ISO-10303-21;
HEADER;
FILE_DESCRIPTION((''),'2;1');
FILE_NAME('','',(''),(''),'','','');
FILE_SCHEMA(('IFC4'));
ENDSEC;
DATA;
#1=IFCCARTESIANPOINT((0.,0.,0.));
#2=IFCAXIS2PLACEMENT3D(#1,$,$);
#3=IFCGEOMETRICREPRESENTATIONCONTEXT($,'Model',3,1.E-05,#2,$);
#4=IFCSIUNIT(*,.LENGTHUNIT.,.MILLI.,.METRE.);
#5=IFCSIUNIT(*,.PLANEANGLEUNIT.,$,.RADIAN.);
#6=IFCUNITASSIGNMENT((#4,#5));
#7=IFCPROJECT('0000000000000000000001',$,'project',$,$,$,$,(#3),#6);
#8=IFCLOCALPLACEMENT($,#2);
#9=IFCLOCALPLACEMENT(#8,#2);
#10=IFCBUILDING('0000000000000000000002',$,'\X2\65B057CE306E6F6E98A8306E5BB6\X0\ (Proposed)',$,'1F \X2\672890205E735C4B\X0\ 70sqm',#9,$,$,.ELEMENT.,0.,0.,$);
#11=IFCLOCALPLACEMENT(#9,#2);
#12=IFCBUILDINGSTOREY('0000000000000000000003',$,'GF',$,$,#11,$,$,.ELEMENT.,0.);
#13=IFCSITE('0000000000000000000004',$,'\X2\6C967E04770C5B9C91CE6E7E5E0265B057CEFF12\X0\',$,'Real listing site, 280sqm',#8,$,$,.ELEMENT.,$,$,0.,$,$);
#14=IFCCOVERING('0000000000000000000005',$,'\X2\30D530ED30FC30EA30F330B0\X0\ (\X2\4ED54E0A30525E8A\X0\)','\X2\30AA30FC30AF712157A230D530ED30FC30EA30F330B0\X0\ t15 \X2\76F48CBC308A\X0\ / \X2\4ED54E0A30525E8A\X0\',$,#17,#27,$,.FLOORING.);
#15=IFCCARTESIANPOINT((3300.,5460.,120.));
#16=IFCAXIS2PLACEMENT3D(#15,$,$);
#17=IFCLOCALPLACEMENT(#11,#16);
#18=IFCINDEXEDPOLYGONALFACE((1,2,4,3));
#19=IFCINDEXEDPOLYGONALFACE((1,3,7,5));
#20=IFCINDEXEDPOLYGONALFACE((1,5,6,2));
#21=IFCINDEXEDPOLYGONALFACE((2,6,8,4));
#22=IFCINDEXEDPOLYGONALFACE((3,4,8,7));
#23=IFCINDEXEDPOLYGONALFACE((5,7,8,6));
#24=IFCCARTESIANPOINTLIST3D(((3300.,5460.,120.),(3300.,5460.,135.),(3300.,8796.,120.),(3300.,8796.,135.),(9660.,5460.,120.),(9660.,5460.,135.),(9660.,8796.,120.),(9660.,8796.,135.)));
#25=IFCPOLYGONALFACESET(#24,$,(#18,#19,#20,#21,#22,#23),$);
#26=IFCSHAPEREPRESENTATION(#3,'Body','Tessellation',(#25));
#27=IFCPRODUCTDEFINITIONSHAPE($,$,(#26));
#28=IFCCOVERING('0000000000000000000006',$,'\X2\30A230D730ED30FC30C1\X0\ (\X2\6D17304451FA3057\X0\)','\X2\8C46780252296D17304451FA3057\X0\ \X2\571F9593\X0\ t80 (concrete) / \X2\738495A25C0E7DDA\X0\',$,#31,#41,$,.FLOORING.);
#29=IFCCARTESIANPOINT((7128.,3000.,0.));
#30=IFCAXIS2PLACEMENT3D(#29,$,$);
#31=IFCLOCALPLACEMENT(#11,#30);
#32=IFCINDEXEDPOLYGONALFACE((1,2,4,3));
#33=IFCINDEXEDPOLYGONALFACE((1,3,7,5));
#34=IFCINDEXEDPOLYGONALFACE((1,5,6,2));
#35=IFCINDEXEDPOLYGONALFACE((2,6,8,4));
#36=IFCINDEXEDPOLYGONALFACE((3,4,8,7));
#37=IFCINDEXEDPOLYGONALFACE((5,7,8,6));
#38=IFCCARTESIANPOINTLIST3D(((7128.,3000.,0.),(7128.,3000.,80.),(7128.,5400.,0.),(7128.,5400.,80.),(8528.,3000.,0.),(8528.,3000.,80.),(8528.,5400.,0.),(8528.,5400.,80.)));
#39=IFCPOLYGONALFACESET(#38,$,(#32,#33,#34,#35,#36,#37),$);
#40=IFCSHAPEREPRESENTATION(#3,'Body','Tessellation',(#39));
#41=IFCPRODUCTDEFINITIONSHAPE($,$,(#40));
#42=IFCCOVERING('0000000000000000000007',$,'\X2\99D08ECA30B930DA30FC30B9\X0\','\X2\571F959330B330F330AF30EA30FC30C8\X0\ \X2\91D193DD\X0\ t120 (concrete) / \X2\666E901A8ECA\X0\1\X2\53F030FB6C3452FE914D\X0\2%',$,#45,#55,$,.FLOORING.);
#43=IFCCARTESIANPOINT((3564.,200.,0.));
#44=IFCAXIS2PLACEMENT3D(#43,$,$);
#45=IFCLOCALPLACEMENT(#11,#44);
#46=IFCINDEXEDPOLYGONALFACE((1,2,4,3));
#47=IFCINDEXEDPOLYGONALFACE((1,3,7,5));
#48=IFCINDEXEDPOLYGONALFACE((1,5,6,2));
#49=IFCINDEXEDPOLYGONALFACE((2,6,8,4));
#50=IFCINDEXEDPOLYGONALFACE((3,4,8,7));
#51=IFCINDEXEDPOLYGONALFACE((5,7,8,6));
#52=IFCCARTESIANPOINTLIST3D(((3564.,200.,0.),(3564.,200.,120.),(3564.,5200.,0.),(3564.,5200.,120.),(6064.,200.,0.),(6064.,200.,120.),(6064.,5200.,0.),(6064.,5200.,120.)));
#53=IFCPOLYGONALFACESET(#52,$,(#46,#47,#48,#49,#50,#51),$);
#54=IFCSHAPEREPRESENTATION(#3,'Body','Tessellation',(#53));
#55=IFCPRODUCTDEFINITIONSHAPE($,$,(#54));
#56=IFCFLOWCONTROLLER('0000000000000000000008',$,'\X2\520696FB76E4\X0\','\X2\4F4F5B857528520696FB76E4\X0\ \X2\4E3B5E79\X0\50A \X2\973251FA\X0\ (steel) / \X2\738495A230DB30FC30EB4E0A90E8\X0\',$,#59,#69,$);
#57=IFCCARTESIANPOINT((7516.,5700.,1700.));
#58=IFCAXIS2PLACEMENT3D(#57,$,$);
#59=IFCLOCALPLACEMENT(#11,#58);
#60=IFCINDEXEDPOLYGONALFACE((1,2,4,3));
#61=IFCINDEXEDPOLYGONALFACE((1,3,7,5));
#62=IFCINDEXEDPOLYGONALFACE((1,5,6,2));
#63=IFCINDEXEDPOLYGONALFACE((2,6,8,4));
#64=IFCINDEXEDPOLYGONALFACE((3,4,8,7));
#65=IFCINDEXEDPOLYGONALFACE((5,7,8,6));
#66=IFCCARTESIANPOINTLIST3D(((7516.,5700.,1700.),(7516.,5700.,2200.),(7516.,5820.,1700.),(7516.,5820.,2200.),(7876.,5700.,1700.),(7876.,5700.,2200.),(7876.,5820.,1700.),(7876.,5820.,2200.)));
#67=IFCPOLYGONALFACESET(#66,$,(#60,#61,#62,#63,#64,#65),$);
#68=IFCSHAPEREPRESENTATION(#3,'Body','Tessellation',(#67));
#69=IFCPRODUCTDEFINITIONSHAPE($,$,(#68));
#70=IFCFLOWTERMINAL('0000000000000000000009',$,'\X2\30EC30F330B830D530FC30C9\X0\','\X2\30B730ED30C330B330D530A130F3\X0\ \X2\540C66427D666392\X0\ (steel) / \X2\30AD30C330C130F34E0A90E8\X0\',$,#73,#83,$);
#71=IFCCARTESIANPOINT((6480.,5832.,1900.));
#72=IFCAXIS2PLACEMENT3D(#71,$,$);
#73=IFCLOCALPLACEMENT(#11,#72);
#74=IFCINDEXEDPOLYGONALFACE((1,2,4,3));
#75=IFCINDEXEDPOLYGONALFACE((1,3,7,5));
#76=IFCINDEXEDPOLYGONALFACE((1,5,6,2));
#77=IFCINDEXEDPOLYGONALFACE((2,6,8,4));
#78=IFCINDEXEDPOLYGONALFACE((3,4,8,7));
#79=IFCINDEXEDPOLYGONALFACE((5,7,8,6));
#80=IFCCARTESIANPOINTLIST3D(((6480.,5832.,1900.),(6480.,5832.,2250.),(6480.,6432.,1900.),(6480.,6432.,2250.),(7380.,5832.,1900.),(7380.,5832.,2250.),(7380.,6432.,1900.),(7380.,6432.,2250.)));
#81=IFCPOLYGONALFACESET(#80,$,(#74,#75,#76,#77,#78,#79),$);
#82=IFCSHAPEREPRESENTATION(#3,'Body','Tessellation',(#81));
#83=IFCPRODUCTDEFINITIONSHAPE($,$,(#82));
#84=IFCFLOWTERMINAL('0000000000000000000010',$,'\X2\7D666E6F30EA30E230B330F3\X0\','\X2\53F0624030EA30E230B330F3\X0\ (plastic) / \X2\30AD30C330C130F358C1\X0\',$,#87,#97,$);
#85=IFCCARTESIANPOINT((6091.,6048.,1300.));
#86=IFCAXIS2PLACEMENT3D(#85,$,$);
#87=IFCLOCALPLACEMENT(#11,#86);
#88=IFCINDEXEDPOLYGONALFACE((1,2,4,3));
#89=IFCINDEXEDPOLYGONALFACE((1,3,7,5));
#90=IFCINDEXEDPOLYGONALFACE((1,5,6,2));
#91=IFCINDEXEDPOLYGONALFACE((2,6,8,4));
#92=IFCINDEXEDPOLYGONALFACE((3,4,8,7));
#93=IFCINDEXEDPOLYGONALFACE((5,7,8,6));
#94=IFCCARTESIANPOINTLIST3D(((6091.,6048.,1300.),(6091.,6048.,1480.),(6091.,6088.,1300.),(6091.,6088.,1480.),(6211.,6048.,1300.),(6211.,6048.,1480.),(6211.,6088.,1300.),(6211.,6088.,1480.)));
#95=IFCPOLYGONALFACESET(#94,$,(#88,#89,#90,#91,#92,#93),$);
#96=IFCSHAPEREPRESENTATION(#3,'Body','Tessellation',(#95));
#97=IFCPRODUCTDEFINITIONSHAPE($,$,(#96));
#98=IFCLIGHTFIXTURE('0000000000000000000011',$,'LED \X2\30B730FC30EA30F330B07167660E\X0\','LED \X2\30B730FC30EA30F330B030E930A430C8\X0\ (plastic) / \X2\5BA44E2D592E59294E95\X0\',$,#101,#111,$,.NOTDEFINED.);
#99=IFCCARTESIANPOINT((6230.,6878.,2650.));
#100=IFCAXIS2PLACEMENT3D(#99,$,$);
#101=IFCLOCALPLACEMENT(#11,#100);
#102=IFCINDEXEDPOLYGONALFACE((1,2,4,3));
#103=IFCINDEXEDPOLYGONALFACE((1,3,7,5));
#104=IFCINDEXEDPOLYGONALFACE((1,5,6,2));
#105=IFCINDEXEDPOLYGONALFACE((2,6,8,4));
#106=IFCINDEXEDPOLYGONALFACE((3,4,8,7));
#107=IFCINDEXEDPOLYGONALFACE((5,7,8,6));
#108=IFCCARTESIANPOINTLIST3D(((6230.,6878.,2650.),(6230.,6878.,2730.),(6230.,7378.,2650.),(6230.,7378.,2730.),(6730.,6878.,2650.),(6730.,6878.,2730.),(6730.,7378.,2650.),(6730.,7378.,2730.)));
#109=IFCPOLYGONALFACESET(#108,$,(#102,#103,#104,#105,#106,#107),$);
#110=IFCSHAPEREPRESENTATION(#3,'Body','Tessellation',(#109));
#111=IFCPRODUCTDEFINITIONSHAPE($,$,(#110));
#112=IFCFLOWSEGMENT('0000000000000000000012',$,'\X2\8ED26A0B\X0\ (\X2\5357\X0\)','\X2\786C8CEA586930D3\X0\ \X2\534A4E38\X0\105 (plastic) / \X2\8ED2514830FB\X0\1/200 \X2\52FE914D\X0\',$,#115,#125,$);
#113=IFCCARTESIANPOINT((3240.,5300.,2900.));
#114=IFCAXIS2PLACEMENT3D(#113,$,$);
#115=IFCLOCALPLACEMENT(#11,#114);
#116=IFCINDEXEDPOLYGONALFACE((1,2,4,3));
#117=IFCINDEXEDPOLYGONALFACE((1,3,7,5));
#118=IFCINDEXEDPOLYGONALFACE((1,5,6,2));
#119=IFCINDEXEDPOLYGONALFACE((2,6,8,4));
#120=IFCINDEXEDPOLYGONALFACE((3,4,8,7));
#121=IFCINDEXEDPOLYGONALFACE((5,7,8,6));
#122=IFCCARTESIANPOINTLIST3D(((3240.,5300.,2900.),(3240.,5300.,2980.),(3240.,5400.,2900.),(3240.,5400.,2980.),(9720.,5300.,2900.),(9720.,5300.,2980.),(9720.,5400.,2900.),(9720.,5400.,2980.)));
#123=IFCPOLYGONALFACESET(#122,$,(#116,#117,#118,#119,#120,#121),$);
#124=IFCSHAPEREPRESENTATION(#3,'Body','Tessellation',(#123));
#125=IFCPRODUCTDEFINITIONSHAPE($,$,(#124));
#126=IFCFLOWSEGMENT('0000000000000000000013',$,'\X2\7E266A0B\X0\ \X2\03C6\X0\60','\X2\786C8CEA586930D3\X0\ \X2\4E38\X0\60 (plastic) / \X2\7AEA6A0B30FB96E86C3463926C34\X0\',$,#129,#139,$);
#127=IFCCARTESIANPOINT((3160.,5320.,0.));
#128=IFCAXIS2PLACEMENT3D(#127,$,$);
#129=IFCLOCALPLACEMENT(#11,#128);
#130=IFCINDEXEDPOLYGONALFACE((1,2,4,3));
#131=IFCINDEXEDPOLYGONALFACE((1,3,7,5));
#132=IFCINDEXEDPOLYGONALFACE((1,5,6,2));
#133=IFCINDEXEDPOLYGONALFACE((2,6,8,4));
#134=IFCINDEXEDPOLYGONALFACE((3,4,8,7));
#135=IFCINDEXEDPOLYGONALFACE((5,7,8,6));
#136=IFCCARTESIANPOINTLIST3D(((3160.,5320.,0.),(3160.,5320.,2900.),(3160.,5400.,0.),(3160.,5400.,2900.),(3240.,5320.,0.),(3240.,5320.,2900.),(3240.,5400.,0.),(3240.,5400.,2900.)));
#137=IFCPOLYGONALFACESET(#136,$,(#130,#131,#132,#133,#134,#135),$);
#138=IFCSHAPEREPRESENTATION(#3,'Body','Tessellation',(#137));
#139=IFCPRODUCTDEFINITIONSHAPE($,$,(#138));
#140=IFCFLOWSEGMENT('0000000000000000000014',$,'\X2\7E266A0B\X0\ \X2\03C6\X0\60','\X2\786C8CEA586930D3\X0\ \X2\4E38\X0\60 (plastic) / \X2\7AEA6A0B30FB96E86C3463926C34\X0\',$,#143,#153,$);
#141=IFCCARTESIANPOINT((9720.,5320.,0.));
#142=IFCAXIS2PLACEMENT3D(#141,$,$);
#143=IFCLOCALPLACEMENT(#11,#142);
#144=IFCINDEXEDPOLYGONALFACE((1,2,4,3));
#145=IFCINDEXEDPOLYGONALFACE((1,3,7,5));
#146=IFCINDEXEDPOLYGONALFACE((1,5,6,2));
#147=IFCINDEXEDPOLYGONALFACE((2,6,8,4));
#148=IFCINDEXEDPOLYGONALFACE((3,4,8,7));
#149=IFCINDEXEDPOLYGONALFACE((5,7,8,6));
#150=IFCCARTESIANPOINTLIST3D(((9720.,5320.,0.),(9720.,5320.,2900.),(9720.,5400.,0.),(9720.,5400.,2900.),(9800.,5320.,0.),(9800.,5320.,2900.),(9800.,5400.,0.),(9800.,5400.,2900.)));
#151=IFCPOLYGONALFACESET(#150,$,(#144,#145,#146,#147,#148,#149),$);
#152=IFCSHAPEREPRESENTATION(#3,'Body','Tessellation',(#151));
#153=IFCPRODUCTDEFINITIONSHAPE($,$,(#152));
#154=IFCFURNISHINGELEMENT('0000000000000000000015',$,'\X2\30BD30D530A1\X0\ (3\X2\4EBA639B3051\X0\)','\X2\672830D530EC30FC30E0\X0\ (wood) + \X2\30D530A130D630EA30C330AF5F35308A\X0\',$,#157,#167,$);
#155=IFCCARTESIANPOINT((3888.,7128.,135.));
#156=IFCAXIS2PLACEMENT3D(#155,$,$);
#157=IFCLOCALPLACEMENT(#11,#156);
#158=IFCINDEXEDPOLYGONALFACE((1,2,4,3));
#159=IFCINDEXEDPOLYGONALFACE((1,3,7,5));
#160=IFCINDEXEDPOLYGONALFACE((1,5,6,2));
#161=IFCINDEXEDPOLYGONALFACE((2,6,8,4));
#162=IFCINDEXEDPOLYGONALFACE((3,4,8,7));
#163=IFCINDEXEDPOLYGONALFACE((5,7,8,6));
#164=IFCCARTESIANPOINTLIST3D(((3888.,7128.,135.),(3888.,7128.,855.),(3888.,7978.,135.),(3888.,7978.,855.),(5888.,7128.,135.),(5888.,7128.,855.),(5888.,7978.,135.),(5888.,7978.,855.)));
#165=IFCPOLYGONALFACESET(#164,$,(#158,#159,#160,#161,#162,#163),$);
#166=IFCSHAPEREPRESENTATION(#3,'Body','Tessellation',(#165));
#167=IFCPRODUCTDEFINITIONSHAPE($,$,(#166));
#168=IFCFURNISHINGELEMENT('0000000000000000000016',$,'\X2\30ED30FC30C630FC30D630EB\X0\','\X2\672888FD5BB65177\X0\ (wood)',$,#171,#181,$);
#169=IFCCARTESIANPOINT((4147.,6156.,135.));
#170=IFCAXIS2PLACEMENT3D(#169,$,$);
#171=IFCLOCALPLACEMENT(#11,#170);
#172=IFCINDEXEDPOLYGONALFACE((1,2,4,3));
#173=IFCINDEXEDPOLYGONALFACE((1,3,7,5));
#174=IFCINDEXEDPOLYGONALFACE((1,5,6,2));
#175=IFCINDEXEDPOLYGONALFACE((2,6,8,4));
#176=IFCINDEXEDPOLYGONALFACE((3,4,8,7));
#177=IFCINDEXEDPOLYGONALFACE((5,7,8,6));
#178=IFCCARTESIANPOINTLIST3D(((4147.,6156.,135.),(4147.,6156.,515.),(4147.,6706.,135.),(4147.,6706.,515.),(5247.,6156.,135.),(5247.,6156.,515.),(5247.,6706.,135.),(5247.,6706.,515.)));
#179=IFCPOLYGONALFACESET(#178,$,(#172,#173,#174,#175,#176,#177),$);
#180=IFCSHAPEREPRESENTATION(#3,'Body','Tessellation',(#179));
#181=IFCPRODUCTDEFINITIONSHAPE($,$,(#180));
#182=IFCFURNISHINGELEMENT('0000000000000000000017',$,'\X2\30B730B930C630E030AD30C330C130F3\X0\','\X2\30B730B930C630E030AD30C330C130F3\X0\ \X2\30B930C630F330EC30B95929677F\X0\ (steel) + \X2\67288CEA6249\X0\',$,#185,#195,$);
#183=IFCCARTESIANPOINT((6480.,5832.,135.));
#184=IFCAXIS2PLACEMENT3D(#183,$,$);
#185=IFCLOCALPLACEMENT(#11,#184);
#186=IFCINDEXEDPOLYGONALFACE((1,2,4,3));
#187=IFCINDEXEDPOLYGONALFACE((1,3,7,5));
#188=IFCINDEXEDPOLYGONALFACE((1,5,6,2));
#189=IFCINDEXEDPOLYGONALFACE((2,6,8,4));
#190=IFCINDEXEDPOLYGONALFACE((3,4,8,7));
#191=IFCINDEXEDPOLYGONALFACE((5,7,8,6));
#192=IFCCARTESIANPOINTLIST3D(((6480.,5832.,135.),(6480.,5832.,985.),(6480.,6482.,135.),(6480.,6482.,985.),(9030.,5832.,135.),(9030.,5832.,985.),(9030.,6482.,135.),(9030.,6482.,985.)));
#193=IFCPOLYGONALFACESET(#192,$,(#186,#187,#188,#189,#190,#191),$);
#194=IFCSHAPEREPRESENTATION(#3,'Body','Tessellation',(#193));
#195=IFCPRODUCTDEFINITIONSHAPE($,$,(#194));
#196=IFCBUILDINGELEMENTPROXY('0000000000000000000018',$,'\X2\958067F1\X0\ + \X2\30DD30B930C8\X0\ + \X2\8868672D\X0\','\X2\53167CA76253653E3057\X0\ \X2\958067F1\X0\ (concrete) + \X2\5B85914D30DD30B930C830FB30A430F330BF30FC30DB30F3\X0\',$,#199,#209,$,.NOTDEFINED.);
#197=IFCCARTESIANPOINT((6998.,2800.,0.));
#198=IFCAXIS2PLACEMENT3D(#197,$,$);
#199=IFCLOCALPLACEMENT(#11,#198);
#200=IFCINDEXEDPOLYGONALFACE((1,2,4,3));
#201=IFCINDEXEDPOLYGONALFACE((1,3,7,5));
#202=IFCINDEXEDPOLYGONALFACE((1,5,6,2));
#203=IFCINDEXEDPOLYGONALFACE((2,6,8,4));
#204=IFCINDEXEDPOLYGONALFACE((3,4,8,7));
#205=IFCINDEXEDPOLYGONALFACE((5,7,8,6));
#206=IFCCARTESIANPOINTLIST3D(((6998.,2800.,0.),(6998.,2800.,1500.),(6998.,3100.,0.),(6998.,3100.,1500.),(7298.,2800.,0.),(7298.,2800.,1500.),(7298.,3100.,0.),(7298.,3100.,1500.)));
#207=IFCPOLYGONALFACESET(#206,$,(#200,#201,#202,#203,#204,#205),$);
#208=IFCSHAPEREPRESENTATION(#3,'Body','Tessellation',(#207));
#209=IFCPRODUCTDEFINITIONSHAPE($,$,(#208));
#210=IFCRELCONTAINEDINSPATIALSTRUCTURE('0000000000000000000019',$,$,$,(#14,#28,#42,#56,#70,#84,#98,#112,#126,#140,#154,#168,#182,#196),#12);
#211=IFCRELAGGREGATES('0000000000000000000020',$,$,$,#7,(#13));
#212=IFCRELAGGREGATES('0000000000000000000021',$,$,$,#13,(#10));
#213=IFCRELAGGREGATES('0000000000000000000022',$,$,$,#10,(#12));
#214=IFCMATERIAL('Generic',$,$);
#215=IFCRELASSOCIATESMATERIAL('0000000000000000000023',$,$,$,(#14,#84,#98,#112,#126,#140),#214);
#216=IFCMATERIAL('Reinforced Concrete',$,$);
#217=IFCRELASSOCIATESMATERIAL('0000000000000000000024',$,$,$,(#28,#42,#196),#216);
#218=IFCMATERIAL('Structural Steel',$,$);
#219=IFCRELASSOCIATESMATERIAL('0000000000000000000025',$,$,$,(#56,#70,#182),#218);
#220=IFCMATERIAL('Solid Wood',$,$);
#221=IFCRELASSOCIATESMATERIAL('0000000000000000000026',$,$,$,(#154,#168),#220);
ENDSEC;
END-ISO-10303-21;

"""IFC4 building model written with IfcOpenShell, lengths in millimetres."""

from ifc_helpers import new_model, si_unit, frame, frame_2d, origin, place, context, project, spatial, rectangle, extrude, material, element, save


model = new_model("IFC4")

# Units and contexts
model_context = context("Model", 3, precision=1e-05, world=origin())
ifc_project = project(units=[si_unit("LENGTHUNIT", "METRE", prefix="MILLI"), si_unit("PLANEANGLEUNIT", "RADIAN")], contexts=[model_context])

# Site, building, storey
site_placement = place(None, origin())
site = spatial("IfcSite", under=ifc_project, at=site_placement, Name="沖縄県宜野湾市新城２", ObjectType="Real listing site, 280sqm", CompositionType="ELEMENT", RefElevation=0.0)
building_placement = place(site_placement, origin())
building = spatial("IfcBuilding", under=site, at=building_placement, Name="新城の潮風の家 (Proposed)", ObjectType="1F 木造平屋 70sqm", CompositionType="ELEMENT", ElevationOfRefHeight=0.0, ElevationOfTerrain=0.0)
storey_placement = place(building_placement, origin())
storey = spatial("IfcBuildingStorey", under=building, at=storey_placement, Name="GF", CompositionType="ELEMENT", Elevation=0.0)

# Shared definitions
ifc_material_1 = material(Name="Solid Wood")

# Shared definitions
ifc_material_2 = material(Name="Reinforced Concrete")

# Shared definitions
ifc_material_3 = material(Name="Structural Steel")

# Coverings
ifc_material_4 = material(Name="Generic")
covering_1_placement = place(storey_placement, frame((3300.0, 5460.0, 120.0)))
element("IfcCovering", 1, at=covering_1_placement, inside=storey, material=ifc_material_4, Name="フローリング (仕上げ床)", Description="オーク無垢フローリング t15 直貼り / 仕上げ床", PredefinedType="FLOORING", context=model_context, shape_type="SweptSolid", body=[
    extrude(rectangle(XDim=6360.0, YDim=3336.0, at=frame_2d((3180.0, 1668.0))), frame((3300.0, 5460.0, 120.0)), (0.0, 0.0, 1.0), 15.0),
])
covering_2_placement = place(storey_placement, frame((7128.0, 3000.0, 0.0)))
element("IfcCovering", 2, at=covering_2_placement, inside=storey, material=ifc_material_2, Name="アプローチ (洗い出し)", Description="豆砂利洗い出し 土間 t80 (concrete) / 玄関導線", PredefinedType="FLOORING", context=model_context, shape_type="SweptSolid", body=[
    extrude(rectangle(XDim=1400.0, YDim=2400.0, at=frame_2d((700.0, 1200.0))), frame((7128.0, 3000.0, 0.0)), (0.0, 0.0, 1.0), 80.0),
])
covering_3_placement = place(storey_placement, frame((3564.0, 200.0, 0.0)))
element("IfcCovering", 3, at=covering_3_placement, inside=storey, material=ifc_material_2, Name="駐車スペース", Description="土間コンクリート 金鏝 t120 (concrete) / 普通車1台・水勾配2%", PredefinedType="FLOORING", context=model_context, shape_type="SweptSolid", body=[
    extrude(rectangle(XDim=2500.0, YDim=5000.0, at=frame_2d((1250.0, 2500.0))), frame((3564.0, 200.0, 0.0)), (0.0, 0.0, 1.0), 120.0),
])

# Flow controller
flow_controller_placement = place(storey_placement, frame((7516.0, 5700.0, 1700.0)))
element("IfcFlowController", 4, at=flow_controller_placement, inside=storey, material=ifc_material_3, Name="分電盤", Description="住宅用分電盤 主幹50A 露出 (steel) / 玄関ホール上部", context=model_context, shape_type="SweptSolid", body=[
    extrude(rectangle(XDim=360.0, YDim=120.0, at=frame_2d((180.0, 60.0))), frame((7516.0, 5700.0, 1700.0)), (0.0, 0.0, 1.0), 500.0),
])

# Flow terminals
flow_terminal_1_placement = place(storey_placement, frame((6480.0, 5832.0, 1900.0)))
element("IfcFlowTerminal", 5, at=flow_terminal_1_placement, inside=storey, material=ifc_material_3, Name="レンジフード", Description="シロッコファン 同時給排 (steel) / キッチン上部", context=model_context, shape_type="SweptSolid", body=[
    extrude(rectangle(XDim=900.0, YDim=600.0, at=frame_2d((450.0, 300.0))), frame((6480.0, 5832.0, 1900.0)), (0.0, 0.0, 1.0), 350.0),
])
flow_terminal_2_placement = place(storey_placement, frame((6091.0, 6048.0, 1300.0)))
element("IfcFlowTerminal", 6, at=flow_terminal_2_placement, inside=storey, material=ifc_material_4, Name="給湯リモコン", Description="台所リモコン (plastic) / キッチン壁", context=model_context, shape_type="SweptSolid", body=[
    extrude(rectangle(XDim=120.0, YDim=40.0, at=frame_2d((60.0, 20.0))), frame((6091.0, 6048.0, 1300.0)), (0.0, 0.0, 1.0), 180.0),
])

# Light fixture
light_fixture_placement = place(storey_placement, frame((6230.0, 6878.0, 2650.0)))
element("IfcLightFixture", 7, at=light_fixture_placement, inside=storey, material=ifc_material_4, Name="LED シーリング照明", Description="LED シーリングライト (plastic) / 室中央天井", PredefinedType="NOTDEFINED", context=model_context, shape_type="SweptSolid", body=[
    extrude(rectangle(XDim=500.0, YDim=500.0, at=frame_2d((250.0, 250.0))), frame((6230.0, 6878.0, 2650.0)), (0.0, 0.0, 1.0), 80.0),
])

# Flow segments
flow_segment_1_placement = place(storey_placement, frame((3240.0, 5300.0, 2900.0)))
element("IfcFlowSegment", 8, at=flow_segment_1_placement, inside=storey, material=ifc_material_4, Name="軒樋 (南)", Description="硬質塩ビ 半丸105 (plastic) / 軒先・1/200 勾配", context=model_context, shape_type="SweptSolid", body=[
    extrude(rectangle(XDim=6480.0, YDim=100.0, at=frame_2d((3240.0, 50.0))), frame((3240.0, 5300.0, 2900.0)), (0.0, 0.0, 1.0), 80.0),
])
flow_segment_2_placement = place(storey_placement, frame((3160.0, 5320.0, 0.0)))
element("IfcFlowSegment", 9, at=flow_segment_2_placement, inside=storey, material=ifc_material_4, Name="縦樋 φ60", Description="硬質塩ビ 丸60 (plastic) / 竪樋・雨水排水", context=model_context, shape_type="SweptSolid", body=[
    extrude(rectangle(XDim=80.0, YDim=80.0, at=frame_2d((40.0, 40.0))), frame((3160.0, 5320.0, 0.0)), (0.0, 0.0, 1.0), 2900.0),
])
flow_segment_3_placement = place(storey_placement, frame((9720.0, 5320.0, 0.0)))
element("IfcFlowSegment", 10, at=flow_segment_3_placement, inside=storey, material=ifc_material_4, Name="縦樋 φ60", Description="硬質塩ビ 丸60 (plastic) / 竪樋・雨水排水", context=model_context, shape_type="SweptSolid", body=[
    extrude(rectangle(XDim=80.0, YDim=80.0, at=frame_2d((40.0, 40.0))), frame((9720.0, 5320.0, 0.0)), (0.0, 0.0, 1.0), 2900.0),
])

# Furnishing elements
furnishing_1_placement = place(storey_placement, frame((3888.0, 7128.0, 135.0)))
element("IfcFurnishingElement", 11, at=furnishing_1_placement, inside=storey, material=ifc_material_1, Name="ソファ (3人掛け)", Description="木フレーム (wood) + ファブリック張り", context=model_context, shape_type="SweptSolid", body=[
    extrude(rectangle(XDim=2000.0, YDim=850.0, at=frame_2d((1000.0, 425.0))), frame((3888.0, 7128.0, 135.0)), (0.0, 0.0, 1.0), 720.0),
])
furnishing_2_placement = place(storey_placement, frame((4147.0, 6156.0, 135.0)))
element("IfcFurnishingElement", 12, at=furnishing_2_placement, inside=storey, material=ifc_material_1, Name="ローテーブル", Description="木製家具 (wood)", context=model_context, shape_type="SweptSolid", body=[
    extrude(rectangle(XDim=1100.0, YDim=550.0, at=frame_2d((550.0, 275.0))), frame((4147.0, 6156.0, 135.0)), (0.0, 0.0, 1.0), 380.0),
])
furnishing_3_placement = place(storey_placement, frame((6480.0, 5832.0, 135.0)))
element("IfcFurnishingElement", 13, at=furnishing_3_placement, inside=storey, material=ifc_material_3, Name="システムキッチン", Description="システムキッチン ステンレス天板 (steel) + 木質扉", context=model_context, shape_type="SweptSolid", body=[
    extrude(rectangle(XDim=2550.0, YDim=650.0, at=frame_2d((1275.0, 325.0))), frame((6480.0, 5832.0, 135.0)), (0.0, 0.0, 1.0), 850.0),
])

# Building element proxy
proxy_placement = place(storey_placement, frame((6998.0, 2800.0, 0.0)))
element("IfcBuildingElementProxy", 14, at=proxy_placement, inside=storey, material=ifc_material_2, Name="門柱 + ポスト + 表札", Description="化粧打放し 門柱 (concrete) + 宅配ポスト・インターホン", PredefinedType="NOTDEFINED", context=model_context, shape_type="SweptSolid", body=[
    extrude(rectangle(XDim=300.0, YDim=300.0, at=frame_2d((150.0, 150.0))), frame((6998.0, 2800.0, 0.0)), (0.0, 0.0, 1.0), 1500.0),
])

save(model, "model.ifc")
